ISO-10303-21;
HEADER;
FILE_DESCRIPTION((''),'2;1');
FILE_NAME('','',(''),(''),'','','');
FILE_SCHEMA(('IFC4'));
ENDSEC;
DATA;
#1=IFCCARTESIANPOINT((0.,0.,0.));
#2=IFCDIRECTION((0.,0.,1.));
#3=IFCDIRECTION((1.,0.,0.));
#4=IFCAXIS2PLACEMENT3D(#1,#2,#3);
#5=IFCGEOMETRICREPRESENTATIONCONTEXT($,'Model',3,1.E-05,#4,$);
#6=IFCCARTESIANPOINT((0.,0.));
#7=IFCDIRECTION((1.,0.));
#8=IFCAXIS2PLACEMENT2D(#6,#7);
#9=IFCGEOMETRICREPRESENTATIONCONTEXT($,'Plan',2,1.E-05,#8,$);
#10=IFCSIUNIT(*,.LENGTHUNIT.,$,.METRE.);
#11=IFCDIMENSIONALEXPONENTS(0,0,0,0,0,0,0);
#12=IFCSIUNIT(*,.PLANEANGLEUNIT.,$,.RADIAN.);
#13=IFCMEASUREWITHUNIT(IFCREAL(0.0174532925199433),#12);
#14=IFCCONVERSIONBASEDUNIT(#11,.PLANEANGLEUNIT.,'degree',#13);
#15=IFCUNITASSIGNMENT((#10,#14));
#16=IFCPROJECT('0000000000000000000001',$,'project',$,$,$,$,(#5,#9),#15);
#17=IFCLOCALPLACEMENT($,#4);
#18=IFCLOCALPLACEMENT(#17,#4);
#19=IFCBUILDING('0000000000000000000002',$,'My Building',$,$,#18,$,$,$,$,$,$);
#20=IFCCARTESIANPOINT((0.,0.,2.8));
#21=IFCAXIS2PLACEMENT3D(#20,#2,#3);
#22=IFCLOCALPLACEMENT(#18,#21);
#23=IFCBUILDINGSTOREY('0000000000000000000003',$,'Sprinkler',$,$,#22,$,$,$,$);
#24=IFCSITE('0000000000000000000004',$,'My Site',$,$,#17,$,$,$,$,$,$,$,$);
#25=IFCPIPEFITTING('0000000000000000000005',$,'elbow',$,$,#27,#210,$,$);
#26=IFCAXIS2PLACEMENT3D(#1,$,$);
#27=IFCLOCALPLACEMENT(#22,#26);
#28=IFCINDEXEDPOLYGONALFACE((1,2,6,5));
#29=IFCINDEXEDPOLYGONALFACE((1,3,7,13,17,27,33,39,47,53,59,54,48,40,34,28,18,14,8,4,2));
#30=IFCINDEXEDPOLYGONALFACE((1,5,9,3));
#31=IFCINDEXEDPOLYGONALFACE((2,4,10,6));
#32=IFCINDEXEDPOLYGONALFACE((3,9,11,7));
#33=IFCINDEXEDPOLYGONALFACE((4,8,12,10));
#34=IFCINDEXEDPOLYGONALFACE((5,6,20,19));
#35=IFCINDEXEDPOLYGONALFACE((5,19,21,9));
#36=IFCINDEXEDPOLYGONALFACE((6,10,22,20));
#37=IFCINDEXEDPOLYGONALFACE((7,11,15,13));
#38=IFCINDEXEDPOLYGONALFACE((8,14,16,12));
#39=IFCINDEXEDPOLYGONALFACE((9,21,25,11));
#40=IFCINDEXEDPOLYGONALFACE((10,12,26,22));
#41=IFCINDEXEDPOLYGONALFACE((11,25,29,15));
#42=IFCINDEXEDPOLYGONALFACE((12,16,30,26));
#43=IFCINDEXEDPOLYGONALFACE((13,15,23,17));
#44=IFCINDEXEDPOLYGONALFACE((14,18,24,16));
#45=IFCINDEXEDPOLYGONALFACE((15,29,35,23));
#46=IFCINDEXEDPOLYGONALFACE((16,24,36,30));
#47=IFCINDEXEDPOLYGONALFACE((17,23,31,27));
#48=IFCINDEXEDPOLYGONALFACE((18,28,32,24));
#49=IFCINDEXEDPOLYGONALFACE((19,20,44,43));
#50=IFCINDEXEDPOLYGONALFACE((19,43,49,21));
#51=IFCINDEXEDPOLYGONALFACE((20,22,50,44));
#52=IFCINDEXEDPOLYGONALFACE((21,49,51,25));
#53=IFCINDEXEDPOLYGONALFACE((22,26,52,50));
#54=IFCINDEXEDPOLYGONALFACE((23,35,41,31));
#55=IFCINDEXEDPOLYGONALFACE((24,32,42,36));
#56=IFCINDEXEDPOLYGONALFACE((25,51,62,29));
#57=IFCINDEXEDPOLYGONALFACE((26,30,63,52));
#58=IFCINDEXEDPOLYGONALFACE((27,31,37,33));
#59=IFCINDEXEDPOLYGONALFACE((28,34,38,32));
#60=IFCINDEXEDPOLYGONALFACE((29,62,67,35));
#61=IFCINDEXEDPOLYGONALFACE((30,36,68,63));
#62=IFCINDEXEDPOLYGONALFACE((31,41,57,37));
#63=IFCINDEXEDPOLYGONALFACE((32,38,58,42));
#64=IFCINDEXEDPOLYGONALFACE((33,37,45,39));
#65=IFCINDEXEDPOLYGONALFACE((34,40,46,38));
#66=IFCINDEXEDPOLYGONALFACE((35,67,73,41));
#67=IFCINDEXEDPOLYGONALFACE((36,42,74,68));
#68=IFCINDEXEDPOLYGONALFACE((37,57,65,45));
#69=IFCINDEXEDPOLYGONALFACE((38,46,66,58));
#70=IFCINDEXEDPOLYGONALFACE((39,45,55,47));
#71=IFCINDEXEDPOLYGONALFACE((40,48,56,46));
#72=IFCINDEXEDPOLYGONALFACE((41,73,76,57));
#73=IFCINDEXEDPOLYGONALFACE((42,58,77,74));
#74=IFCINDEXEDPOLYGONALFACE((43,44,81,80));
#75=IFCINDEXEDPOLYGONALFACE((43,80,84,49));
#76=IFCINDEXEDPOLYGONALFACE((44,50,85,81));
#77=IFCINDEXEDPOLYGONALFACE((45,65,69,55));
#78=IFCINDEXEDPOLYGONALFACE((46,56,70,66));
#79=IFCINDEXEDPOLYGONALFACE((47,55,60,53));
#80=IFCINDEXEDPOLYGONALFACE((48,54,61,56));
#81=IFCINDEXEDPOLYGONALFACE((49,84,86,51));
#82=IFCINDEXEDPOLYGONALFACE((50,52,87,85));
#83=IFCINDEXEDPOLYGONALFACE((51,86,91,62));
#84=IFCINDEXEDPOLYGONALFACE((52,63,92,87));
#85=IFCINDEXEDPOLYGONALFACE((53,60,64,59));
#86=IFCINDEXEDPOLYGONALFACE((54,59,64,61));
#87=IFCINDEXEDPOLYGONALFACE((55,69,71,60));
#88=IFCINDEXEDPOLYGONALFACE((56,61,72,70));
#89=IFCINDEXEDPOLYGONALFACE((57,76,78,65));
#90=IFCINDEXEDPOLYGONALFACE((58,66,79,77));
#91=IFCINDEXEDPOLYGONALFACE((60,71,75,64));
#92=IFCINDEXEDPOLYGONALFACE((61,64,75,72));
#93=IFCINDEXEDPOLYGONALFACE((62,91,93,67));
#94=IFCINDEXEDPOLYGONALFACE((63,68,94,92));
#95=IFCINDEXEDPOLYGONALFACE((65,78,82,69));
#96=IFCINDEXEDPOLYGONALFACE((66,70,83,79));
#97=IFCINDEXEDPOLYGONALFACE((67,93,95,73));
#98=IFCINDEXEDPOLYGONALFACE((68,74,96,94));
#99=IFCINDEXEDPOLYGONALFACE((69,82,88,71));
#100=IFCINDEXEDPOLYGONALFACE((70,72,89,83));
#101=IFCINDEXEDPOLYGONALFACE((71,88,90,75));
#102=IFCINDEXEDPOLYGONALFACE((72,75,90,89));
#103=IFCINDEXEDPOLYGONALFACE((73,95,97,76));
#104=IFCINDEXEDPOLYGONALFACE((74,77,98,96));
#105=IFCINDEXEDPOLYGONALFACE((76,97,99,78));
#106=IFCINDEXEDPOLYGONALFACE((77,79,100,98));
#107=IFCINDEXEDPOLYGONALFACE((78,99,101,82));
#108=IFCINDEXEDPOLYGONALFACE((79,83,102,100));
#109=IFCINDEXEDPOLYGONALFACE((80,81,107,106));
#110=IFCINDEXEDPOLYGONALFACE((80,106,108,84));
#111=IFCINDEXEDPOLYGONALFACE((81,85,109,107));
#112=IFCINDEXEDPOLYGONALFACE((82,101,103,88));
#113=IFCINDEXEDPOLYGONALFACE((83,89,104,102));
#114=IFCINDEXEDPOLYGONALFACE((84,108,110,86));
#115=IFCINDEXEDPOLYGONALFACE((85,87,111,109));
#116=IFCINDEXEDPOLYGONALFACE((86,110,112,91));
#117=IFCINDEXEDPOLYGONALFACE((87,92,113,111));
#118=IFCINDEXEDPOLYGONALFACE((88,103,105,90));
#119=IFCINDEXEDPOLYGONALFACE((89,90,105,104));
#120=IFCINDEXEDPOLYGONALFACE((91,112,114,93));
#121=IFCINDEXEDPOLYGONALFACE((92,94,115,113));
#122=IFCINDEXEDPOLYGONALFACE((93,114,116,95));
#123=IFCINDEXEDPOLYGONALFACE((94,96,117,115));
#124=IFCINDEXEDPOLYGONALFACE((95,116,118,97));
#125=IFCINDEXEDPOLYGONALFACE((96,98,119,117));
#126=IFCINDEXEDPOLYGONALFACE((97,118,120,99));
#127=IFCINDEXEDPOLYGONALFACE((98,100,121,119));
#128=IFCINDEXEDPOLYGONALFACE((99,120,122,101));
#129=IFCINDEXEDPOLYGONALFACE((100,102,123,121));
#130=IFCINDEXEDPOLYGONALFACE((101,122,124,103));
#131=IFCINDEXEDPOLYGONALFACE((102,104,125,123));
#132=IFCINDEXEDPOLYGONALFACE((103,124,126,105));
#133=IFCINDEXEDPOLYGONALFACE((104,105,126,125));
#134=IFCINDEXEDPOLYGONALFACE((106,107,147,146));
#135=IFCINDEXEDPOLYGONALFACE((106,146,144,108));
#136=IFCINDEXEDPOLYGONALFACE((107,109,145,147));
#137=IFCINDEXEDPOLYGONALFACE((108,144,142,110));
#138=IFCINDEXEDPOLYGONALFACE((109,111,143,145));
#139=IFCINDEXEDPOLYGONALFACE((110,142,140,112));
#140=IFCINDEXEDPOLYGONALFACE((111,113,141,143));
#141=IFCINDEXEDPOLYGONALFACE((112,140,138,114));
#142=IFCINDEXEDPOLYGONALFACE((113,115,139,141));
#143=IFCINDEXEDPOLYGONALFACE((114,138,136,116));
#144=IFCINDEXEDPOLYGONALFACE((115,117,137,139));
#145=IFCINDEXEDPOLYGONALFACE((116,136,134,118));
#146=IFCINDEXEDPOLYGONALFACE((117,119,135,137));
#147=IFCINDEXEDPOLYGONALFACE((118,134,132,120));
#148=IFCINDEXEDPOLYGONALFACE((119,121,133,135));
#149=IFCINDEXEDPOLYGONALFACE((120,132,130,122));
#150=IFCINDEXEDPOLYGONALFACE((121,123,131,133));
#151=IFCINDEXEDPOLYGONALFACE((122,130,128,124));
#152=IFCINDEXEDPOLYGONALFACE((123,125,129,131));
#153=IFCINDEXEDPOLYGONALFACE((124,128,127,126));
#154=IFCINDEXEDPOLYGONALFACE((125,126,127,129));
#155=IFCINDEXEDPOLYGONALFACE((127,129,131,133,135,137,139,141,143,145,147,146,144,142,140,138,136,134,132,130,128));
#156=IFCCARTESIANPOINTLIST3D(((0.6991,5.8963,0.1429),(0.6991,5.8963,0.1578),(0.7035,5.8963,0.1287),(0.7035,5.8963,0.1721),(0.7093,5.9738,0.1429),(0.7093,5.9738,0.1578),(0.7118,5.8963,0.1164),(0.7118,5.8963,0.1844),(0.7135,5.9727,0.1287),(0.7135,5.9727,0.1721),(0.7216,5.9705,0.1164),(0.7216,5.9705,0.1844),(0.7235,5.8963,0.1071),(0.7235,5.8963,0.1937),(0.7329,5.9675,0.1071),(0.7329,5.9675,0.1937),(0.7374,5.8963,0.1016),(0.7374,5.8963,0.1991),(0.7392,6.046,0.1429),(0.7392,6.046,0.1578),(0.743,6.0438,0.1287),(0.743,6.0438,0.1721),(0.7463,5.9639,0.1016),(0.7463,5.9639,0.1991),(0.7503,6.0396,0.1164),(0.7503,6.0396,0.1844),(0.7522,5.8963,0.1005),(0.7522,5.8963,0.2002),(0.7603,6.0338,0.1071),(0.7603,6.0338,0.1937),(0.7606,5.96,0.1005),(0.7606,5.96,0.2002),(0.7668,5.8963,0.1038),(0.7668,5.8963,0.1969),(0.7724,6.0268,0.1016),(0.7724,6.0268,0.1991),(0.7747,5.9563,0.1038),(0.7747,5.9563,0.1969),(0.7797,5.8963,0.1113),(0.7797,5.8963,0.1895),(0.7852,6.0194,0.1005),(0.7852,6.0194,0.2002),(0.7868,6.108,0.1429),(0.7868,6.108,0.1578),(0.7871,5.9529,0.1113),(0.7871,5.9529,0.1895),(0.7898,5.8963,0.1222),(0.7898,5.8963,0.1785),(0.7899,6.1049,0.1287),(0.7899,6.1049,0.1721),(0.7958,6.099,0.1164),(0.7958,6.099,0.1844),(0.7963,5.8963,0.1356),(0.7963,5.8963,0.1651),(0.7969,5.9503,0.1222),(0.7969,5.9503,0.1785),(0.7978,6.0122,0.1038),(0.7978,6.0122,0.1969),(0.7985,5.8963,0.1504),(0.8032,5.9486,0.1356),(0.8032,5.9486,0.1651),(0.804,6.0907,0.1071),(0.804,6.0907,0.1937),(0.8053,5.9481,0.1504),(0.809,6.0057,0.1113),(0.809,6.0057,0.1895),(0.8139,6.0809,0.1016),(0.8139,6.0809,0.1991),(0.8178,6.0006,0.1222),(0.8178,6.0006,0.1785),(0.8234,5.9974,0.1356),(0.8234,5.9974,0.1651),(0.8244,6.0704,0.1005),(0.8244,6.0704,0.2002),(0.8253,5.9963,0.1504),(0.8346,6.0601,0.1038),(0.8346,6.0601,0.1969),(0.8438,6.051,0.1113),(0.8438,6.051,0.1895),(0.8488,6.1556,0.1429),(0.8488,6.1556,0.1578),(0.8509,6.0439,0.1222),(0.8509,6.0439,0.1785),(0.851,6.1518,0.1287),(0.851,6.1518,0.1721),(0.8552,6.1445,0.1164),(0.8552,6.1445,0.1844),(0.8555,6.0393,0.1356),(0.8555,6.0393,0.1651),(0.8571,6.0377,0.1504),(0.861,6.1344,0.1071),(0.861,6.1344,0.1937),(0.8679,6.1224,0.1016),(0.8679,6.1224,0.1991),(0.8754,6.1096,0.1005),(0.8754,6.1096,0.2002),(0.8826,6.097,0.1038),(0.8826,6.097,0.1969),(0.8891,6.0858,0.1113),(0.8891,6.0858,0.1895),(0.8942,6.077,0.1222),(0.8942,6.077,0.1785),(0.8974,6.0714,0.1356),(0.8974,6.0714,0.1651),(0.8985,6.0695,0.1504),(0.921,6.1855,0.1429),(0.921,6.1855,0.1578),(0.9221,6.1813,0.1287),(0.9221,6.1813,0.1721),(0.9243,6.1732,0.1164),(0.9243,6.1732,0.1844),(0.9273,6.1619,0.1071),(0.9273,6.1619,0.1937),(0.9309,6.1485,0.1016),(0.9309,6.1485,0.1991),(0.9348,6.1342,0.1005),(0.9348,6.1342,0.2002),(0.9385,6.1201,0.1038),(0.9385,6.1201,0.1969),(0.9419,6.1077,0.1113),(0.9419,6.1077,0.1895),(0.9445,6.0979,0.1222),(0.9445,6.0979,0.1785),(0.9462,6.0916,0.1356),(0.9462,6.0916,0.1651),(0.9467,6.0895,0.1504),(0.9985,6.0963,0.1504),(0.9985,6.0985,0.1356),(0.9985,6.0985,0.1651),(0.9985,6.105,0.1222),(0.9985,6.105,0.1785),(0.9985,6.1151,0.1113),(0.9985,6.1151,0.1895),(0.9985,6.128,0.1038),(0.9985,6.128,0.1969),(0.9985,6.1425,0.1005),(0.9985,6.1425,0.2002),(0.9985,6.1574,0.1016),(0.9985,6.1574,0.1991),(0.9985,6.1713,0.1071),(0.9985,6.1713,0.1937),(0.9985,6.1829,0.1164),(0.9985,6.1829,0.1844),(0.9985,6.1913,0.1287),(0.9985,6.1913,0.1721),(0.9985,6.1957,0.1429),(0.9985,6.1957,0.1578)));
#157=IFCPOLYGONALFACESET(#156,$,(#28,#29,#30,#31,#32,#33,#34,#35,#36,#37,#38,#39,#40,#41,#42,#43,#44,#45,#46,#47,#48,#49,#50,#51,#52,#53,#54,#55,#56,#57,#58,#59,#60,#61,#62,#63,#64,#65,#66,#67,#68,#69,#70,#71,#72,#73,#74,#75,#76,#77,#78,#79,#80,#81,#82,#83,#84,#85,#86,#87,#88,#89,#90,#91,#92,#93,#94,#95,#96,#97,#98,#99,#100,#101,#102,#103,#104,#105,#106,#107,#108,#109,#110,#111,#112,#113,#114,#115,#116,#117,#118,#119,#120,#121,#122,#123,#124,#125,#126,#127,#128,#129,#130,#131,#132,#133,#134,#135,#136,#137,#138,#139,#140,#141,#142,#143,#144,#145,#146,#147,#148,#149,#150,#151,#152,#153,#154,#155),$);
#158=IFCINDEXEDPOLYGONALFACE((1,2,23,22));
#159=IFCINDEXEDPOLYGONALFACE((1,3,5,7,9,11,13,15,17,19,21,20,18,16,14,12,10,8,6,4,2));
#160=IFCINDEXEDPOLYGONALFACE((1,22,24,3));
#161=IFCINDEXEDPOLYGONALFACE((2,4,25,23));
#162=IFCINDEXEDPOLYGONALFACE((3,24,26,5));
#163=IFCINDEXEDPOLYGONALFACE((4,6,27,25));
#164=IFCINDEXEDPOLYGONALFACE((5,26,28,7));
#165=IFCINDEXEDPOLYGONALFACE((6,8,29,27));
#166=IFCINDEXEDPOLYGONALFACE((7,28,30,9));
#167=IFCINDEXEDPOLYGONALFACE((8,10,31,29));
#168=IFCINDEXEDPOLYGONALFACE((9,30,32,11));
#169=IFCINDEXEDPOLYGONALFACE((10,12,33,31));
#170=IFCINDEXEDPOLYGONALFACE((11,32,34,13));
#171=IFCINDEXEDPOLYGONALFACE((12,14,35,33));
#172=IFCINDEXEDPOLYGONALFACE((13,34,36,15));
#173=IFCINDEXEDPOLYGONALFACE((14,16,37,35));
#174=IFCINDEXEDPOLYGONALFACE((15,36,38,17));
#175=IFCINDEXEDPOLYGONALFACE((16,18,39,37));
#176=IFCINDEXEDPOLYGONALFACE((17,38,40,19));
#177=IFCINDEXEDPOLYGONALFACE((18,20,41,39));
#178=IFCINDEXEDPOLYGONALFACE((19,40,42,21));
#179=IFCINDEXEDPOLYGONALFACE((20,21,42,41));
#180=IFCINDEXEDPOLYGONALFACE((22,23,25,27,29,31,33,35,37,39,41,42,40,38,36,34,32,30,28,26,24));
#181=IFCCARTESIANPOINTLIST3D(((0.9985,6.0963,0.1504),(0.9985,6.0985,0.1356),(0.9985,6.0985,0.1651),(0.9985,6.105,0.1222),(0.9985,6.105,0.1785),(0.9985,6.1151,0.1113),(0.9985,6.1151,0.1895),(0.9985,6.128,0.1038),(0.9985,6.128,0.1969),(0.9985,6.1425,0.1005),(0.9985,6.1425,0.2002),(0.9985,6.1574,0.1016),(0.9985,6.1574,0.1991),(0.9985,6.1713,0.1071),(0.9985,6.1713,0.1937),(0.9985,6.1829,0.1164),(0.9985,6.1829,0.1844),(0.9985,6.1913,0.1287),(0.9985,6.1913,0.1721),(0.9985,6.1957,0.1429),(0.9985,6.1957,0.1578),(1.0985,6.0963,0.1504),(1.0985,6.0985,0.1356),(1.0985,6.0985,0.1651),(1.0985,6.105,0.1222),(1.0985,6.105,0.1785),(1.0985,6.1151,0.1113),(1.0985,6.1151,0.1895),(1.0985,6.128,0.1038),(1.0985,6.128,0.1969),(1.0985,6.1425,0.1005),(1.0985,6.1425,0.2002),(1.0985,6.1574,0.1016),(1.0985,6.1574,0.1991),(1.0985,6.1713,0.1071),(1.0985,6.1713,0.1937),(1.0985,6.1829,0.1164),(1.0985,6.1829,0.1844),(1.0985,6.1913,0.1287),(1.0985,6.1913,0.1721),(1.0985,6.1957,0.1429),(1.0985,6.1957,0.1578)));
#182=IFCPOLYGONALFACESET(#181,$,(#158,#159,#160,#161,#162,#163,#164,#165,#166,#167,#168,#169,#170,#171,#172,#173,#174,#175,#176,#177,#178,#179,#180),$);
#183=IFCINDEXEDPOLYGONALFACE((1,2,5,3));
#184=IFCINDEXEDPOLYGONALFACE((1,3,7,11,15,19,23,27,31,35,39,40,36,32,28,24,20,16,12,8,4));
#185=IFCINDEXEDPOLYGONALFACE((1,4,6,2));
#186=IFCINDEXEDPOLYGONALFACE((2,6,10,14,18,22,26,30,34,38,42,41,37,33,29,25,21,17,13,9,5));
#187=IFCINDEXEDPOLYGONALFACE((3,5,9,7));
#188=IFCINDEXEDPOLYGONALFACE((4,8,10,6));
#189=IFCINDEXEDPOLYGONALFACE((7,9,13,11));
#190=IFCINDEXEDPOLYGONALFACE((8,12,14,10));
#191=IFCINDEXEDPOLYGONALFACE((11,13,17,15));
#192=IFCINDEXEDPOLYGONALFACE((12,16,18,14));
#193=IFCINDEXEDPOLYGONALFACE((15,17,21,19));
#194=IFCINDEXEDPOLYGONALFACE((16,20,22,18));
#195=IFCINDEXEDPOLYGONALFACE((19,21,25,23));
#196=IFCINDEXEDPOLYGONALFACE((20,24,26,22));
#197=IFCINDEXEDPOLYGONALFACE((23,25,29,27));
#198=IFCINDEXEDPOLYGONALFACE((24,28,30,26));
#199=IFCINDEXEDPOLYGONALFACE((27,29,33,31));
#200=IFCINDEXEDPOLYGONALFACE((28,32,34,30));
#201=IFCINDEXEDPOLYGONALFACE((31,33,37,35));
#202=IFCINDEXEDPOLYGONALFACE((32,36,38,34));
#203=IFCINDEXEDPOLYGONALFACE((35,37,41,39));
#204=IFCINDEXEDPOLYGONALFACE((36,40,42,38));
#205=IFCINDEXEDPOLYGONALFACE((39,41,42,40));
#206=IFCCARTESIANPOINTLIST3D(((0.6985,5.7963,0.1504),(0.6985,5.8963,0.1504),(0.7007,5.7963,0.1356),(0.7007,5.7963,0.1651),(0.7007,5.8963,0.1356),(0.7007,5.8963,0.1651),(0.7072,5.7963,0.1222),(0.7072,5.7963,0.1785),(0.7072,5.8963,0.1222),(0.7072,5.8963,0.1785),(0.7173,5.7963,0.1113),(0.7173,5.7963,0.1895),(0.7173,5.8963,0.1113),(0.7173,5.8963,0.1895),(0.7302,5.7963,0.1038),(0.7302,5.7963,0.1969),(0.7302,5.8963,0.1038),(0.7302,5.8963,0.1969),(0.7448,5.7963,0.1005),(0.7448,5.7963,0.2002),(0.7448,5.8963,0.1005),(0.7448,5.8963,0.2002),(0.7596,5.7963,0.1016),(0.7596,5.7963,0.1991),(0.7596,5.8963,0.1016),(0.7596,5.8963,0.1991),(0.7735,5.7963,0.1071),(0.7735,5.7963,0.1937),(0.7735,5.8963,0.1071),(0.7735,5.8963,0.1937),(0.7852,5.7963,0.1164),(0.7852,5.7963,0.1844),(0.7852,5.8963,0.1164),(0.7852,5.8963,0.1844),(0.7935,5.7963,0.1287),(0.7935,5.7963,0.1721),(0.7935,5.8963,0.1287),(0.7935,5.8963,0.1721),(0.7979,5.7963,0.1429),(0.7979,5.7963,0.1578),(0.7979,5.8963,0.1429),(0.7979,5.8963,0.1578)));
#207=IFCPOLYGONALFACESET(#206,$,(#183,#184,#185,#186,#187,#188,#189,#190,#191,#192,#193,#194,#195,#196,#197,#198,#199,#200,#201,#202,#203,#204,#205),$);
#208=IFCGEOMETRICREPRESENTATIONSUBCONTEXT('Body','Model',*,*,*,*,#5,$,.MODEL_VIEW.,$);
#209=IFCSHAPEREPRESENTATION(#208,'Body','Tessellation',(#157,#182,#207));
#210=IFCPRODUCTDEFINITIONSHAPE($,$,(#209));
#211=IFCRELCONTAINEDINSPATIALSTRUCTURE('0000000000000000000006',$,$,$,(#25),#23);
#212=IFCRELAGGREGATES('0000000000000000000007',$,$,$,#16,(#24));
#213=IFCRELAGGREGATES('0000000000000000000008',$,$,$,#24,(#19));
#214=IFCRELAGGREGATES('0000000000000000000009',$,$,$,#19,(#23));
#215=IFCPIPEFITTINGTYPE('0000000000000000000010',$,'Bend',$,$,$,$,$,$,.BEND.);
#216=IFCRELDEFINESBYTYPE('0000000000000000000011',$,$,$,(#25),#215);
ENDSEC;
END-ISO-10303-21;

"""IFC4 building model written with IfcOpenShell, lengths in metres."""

from ifc_helpers import new_model, entity, si_unit, converted_unit, frame, origin_with_axes, origin_2d_with_axis, place, context, subcontext, project, spatial, circle, extrude, source, transform, mapped, type_object, type_shapes, element, save


model = new_model("IFC4")

# Units and contexts
model_context = context("Model", 3, precision=1e-05, world=origin_with_axes())
plan_context = context("Plan", 2, precision=1e-05, world=origin_2d_with_axis())
body_context = subcontext(model_context, "Body", "Model", "MODEL_VIEW")
ifc_project = project(units=[si_unit("LENGTHUNIT", "METRE"), converted_unit("PLANEANGLEUNIT", "degree", entity("IfcReal", 0.0174532925199433), si_unit("PLANEANGLEUNIT", "RADIAN"), dimensions=[0, 0, 0, 0, 0, 0, 0])], contexts=[model_context, plan_context])

# Site, building, storey
site_placement = place(None, origin_with_axes())
site = spatial("IfcSite", under=ifc_project, at=site_placement, Name="My Site")
building_placement = place(site_placement, origin_with_axes())
building = spatial("IfcBuilding", under=site, at=building_placement, Name="My Building")
storey_placement = place(building_placement, frame((0.0, 0.0, 2.8), z_axis=(0.0, 0.0, 1.0), x_axis=(1.0, 0.0, 0.0)))
storey = spatial("IfcBuildingStorey", under=building, at=storey_placement, Name="Sprinkler")

# Pipe fitting
pipe_fitting_type_1 = type_object("IfcPipeFittingType", Name="Bend", PredefinedType="BEND")
shared_shape = source(origin_with_axes(), body_context, "Body", "SolidModel", [
    entity("IfcSweptDiskSolid", entity("IfcIndexedPolyCurve", entity("IfcCartesianPointList3D", [[0.0, 0.0, 0.1], [0.0732, 0.0, 0.2768], [0.25, 0.0, 0.35]]), [entity("IfcArcIndex", [1, 2, 3])]), 0.05),
    extrude(circle(Radius=0.05), origin_with_axes(), (0.0, 0.0, 1.0), 0.1),
    extrude(circle(Radius=0.05), frame((0.25, 0.0, 0.35), z_axis=(1.0, 0.0, 0.000001), x_axis=(-0.000001, 0.0, 1.0)), (0.0, 0.0, 1.0), 0.1),
])
type_shapes(pipe_fitting_type_1, [shared_shape])
for number, where, z_axis, x_axis, name in (
    (1, (1.0985, 6.1463, 0.1504), (-1.0, -0.000001, 0.0), (0.000001, -1.0, 0.0), "elbow"),
):
    element("IfcPipeFitting", number, at=place(storey_placement, frame(where, z_axis=z_axis, x_axis=x_axis)), inside=storey, type_object=pipe_fitting_type_1, Name=name, context=body_context, shape_type="MappedRepresentation", body=[
        mapped(shared_shape, transform((0.0, 0.0, 0.0), x_axis=(1.0, 0.0, 0.0), y_axis=(0.0, 1.0, 0.0), z_axis=(0.0, 0.0, 1.0), scale=1.0)),
    ])

save(model, "model.ifc")
